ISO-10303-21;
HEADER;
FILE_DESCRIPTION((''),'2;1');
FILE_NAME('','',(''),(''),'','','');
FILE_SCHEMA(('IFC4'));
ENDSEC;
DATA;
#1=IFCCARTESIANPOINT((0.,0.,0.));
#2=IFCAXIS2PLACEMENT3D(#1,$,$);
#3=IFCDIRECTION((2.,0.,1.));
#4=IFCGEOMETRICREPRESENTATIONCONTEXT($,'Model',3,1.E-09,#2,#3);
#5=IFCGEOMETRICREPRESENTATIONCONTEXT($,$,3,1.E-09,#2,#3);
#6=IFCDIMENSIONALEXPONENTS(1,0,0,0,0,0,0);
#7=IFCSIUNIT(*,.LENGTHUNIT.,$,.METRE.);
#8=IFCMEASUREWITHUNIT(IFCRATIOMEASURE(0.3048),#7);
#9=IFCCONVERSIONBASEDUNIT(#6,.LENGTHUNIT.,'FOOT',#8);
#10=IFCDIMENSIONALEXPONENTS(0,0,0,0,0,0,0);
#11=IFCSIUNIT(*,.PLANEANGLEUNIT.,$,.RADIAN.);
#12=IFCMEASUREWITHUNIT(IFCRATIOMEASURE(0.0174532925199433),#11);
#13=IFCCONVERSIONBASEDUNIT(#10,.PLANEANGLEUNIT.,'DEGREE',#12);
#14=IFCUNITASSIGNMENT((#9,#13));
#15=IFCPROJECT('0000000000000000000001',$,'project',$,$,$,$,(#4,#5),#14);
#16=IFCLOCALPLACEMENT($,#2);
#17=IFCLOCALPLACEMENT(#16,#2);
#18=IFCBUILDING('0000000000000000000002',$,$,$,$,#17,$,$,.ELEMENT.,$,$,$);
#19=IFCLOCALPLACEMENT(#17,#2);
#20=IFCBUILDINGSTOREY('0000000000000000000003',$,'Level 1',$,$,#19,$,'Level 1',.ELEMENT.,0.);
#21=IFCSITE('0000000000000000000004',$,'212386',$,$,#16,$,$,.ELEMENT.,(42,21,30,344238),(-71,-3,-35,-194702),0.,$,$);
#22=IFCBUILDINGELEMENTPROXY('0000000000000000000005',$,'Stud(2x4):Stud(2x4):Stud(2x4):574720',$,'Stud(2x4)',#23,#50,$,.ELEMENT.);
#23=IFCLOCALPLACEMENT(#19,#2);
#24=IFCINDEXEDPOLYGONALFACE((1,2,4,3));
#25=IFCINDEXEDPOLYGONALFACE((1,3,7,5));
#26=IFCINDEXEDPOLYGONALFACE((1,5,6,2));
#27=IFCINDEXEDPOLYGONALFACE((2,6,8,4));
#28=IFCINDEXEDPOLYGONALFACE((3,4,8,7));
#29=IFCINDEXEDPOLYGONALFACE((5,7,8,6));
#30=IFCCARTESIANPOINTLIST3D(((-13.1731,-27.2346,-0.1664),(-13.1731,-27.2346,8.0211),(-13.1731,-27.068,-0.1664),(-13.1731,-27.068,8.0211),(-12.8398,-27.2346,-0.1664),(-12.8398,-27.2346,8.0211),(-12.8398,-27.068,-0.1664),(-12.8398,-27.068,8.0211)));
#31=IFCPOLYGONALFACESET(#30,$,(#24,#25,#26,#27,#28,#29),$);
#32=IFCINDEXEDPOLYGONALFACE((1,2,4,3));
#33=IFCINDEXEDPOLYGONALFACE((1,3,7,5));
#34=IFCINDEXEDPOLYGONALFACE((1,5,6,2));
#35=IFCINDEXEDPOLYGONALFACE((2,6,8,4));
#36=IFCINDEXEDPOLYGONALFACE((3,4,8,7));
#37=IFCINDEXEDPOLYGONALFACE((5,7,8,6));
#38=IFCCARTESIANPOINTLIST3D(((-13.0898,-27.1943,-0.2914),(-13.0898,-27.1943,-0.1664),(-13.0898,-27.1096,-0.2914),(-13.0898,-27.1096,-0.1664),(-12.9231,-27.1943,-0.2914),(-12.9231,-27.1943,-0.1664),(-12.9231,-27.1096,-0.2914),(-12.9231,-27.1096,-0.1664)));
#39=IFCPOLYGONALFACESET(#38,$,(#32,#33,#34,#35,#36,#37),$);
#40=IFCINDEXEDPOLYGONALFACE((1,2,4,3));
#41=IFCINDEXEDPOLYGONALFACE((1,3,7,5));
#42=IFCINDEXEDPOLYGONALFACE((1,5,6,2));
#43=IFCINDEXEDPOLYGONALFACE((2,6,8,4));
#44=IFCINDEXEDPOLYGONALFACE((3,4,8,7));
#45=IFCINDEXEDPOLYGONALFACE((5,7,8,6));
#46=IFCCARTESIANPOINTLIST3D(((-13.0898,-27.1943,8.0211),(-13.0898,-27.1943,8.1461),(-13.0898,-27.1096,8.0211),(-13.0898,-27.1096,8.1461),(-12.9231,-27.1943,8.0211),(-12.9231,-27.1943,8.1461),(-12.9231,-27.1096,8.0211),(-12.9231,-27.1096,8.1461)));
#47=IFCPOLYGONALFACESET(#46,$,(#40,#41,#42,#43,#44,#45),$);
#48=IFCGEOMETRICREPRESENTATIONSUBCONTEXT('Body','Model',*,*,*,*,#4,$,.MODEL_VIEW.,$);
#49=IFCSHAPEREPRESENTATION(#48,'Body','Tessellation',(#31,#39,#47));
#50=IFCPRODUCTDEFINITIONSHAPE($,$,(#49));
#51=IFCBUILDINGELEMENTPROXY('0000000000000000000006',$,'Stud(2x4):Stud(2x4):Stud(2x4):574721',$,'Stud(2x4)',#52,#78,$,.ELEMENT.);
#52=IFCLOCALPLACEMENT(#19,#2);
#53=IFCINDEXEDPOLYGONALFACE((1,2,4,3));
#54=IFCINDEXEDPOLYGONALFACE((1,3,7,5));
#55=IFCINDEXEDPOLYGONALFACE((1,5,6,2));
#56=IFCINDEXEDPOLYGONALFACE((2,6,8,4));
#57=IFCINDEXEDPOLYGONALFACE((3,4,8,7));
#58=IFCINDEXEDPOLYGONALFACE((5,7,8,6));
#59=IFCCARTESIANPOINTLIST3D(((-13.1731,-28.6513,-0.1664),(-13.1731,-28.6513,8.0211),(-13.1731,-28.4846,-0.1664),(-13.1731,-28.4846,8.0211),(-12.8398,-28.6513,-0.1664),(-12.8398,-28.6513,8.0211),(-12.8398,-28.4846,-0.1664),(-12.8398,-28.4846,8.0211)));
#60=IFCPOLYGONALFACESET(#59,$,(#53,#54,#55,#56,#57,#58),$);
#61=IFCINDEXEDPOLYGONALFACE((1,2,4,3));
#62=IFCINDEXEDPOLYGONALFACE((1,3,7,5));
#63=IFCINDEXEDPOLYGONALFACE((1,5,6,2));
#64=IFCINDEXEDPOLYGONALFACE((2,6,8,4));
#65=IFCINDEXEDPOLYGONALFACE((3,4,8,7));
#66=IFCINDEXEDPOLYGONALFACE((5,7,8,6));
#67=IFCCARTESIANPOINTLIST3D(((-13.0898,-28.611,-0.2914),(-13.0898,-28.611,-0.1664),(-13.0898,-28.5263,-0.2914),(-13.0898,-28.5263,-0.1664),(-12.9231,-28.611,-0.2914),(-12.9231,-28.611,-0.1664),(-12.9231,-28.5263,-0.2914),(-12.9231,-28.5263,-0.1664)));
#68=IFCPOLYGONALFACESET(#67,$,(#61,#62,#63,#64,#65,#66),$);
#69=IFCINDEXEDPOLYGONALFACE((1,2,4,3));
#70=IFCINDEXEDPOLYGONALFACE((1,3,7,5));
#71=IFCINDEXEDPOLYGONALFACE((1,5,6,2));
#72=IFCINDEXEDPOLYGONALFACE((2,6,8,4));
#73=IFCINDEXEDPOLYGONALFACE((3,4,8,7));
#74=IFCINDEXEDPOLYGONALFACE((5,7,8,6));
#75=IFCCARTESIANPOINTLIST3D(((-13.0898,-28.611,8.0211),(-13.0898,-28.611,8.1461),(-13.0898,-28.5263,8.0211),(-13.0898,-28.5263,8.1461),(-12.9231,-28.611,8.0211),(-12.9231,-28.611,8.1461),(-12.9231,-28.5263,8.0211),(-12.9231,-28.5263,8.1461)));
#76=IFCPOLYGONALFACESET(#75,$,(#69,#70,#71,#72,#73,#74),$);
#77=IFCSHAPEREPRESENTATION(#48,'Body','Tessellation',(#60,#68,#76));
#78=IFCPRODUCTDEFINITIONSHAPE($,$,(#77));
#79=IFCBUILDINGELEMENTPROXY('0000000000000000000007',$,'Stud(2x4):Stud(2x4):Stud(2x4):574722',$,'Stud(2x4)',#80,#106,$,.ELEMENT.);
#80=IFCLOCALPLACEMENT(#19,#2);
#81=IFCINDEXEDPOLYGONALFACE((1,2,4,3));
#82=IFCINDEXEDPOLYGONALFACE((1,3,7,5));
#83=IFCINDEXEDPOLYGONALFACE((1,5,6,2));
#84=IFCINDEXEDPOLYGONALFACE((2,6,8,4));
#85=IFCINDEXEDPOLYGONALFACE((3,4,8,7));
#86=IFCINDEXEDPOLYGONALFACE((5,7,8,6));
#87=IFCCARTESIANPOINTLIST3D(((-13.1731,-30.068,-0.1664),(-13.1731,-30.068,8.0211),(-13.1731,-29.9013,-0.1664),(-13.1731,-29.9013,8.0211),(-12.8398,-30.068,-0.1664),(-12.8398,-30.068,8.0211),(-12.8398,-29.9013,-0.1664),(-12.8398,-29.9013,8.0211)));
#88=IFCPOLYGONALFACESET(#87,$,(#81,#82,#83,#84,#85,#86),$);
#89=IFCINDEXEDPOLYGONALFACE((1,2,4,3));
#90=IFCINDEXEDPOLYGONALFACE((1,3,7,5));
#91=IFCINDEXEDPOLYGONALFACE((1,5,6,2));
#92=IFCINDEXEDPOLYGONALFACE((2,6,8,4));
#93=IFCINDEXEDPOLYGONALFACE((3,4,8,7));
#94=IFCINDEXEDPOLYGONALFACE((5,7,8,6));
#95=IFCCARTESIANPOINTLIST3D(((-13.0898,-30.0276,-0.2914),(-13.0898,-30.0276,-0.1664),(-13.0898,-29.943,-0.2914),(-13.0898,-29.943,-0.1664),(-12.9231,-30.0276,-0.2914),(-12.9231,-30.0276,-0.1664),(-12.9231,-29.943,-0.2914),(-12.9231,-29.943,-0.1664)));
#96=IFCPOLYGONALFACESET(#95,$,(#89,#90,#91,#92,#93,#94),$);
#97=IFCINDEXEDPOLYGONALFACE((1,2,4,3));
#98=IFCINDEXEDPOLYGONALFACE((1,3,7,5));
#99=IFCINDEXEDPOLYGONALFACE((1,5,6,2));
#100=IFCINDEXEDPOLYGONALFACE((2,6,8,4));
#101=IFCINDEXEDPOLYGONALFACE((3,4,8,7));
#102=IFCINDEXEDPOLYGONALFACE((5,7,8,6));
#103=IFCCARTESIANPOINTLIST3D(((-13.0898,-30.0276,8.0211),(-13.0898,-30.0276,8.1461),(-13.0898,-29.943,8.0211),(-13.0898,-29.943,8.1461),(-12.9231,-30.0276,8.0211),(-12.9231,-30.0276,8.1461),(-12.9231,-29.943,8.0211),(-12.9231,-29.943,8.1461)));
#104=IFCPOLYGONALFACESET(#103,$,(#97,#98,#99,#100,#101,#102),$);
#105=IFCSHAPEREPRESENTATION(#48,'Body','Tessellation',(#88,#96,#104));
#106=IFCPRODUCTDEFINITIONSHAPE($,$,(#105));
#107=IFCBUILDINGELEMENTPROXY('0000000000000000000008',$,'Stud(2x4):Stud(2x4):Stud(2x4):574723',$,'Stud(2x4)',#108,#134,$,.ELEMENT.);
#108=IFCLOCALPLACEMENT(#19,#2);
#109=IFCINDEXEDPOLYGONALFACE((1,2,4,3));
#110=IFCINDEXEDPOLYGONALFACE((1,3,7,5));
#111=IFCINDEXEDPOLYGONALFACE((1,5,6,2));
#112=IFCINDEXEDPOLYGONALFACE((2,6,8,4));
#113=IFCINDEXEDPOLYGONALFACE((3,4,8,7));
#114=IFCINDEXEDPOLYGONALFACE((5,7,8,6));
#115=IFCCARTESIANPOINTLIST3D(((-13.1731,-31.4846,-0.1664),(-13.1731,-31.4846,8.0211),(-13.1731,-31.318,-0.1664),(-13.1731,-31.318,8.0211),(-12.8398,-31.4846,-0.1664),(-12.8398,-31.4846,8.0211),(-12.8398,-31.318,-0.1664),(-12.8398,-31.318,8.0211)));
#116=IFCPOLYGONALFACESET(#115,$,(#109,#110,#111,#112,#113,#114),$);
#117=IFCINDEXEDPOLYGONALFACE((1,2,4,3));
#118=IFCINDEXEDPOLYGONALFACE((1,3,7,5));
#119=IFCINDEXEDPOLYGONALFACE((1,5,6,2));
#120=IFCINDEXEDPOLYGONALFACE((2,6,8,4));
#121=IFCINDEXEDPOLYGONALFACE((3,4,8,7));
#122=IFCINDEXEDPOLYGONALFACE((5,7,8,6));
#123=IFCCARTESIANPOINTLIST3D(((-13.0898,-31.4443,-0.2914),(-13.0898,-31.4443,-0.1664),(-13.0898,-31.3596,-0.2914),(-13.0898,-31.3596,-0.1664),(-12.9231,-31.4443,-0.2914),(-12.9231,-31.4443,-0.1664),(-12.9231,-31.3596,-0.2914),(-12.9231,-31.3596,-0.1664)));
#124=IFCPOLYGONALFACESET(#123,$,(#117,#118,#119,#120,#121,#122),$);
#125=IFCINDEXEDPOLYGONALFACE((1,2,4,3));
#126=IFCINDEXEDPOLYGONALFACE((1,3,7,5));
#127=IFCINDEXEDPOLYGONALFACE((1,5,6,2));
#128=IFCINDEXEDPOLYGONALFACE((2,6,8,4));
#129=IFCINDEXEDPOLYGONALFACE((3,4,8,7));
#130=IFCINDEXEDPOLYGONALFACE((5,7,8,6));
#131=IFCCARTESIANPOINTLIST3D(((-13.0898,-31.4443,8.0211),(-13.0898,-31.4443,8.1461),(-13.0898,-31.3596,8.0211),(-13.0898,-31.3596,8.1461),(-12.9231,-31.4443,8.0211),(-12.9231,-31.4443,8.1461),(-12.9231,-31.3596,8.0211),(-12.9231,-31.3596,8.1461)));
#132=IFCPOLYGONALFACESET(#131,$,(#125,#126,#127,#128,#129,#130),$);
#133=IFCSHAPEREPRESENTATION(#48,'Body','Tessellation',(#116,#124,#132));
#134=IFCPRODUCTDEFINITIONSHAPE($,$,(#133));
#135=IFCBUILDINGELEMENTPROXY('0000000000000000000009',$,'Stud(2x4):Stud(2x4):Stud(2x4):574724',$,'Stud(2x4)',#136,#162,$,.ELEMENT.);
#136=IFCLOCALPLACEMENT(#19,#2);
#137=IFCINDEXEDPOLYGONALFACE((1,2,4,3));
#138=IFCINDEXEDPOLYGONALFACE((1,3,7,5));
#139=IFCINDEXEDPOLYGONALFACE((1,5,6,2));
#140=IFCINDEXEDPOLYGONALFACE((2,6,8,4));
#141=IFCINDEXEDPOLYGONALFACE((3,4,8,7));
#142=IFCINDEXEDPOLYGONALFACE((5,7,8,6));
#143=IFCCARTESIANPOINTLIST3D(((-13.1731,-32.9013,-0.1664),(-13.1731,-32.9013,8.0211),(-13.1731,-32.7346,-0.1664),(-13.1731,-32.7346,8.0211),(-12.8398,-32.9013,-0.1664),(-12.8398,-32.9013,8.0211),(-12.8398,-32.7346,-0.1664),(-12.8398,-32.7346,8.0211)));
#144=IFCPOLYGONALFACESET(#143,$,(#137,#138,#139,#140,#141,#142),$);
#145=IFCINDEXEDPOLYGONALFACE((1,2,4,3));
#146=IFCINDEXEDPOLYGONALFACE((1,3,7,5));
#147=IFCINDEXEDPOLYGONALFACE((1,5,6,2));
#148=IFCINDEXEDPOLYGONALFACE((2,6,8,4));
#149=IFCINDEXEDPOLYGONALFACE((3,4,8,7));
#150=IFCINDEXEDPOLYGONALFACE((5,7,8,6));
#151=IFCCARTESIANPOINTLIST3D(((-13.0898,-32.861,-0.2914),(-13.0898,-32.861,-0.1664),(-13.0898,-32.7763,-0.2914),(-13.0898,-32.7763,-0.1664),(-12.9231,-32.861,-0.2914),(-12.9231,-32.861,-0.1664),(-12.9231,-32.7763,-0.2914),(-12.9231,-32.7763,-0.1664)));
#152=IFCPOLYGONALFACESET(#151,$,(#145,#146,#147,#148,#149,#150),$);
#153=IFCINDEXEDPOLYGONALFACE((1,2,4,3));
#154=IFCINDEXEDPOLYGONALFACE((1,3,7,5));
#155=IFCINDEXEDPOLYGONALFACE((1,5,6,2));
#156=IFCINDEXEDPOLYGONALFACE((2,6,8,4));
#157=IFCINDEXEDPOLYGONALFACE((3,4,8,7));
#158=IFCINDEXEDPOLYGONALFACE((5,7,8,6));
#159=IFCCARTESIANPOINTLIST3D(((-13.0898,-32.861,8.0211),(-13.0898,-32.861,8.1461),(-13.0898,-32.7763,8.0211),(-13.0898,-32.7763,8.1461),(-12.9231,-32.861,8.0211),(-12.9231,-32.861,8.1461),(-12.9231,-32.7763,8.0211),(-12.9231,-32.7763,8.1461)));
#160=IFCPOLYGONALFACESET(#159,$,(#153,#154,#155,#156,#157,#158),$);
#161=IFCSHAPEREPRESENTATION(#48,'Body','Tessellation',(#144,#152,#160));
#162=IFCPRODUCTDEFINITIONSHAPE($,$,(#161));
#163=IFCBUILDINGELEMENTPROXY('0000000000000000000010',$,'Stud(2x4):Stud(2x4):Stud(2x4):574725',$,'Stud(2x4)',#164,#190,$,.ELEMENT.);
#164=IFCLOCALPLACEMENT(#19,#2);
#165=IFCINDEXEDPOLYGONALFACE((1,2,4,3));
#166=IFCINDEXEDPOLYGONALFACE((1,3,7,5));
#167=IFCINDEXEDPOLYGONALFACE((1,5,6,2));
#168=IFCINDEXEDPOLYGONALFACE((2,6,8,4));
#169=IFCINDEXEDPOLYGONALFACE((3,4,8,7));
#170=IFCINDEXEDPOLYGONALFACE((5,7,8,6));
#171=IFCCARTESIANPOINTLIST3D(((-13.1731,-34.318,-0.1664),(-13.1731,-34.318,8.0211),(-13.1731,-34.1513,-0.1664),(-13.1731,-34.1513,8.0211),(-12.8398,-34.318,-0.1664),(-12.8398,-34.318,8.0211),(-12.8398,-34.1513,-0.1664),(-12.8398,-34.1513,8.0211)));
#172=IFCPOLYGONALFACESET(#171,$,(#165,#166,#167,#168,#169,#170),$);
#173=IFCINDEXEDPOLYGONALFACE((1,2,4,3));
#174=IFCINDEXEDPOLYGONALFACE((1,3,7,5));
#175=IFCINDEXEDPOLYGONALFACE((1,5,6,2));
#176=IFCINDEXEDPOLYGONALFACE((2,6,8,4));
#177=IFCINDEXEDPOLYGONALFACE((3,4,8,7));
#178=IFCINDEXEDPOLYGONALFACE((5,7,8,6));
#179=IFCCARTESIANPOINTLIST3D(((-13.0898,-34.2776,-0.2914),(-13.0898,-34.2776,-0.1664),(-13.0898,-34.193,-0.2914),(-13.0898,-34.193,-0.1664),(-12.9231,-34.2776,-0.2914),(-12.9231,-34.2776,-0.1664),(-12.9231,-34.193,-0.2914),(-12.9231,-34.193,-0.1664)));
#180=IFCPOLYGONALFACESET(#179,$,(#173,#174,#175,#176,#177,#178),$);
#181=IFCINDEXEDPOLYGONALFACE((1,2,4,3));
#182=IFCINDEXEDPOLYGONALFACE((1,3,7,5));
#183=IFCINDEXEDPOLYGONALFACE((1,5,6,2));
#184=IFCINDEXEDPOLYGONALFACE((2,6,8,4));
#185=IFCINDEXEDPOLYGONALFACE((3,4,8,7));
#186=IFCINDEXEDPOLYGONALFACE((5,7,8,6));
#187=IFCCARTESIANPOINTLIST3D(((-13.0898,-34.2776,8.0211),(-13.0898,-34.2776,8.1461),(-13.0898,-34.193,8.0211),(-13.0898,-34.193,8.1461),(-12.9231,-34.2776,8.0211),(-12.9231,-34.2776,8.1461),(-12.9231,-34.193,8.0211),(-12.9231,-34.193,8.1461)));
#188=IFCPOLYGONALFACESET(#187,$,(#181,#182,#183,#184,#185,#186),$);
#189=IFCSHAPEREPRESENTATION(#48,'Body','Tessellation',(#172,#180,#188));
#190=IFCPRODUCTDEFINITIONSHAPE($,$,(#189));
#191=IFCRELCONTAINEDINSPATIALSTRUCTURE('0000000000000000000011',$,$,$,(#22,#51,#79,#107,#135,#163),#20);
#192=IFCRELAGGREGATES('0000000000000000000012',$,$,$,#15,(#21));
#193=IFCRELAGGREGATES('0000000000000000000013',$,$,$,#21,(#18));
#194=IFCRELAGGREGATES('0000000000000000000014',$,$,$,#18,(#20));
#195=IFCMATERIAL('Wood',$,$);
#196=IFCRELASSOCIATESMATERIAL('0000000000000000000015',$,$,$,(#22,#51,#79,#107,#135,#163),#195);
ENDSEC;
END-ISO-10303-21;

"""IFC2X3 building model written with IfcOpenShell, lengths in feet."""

from ifc_helpers import new_model, entity, si_unit, converted_unit, direction, frame, frame_2d, origin, place, context, subcontext, project, spatial, rectangle, extrude, source, transform, mapped, material, element, save


model = new_model("IFC2X3")

# Units and contexts
model_context = context("Model", 3, precision=1e-09, world=origin(), true_north=direction((2.0, 0.0, 1.0)))
context_of_model = context(None, 3, precision=1e-09, world=origin(), true_north=direction((2.0, 0.0, 1.0)))
body_context = subcontext(model_context, "Body", "Model", "MODEL_VIEW")
ifc_project = project(units=[converted_unit("LENGTHUNIT", "FOOT", entity("IfcRatioMeasure", 0.3048), si_unit("LENGTHUNIT", "METRE"), dimensions=[1, 0, 0, 0, 0, 0, 0]), converted_unit("PLANEANGLEUNIT", "DEGREE", entity("IfcRatioMeasure", 0.0174532925199433), si_unit("PLANEANGLEUNIT", "RADIAN"), dimensions=[0, 0, 0, 0, 0, 0, 0])], contexts=[model_context, context_of_model])

# Site, building, storey
site_placement = place(None, origin())
site = spatial("IfcSite", under=ifc_project, at=site_placement, Name="212386", CompositionType="ELEMENT", RefLatitude=(42, 21, 30, 344238), RefLongitude=(-71, -3, -35, -194702), RefElevation=0.0)
building_placement = place(site_placement, origin())
building = spatial("IfcBuilding", under=site, at=building_placement, CompositionType="ELEMENT")
storey_placement = place(building_placement, origin())
storey = spatial("IfcBuildingStorey", under=building, at=storey_placement, Name="Level 1", LongName="Level 1", CompositionType="ELEMENT", Elevation=0.0)

# Building element proxies
ifc_material = material(Name="Wood")
shared_shape_1 = source(origin(), body_context, "Body", "SweptSolid", [
    extrude(rectangle(XDim=0.3333, YDim=0.1667, at=frame_2d((0.0, 0.0), x_axis=(1.0, 0.0))), frame((-13.0064, -27.1513, -0.1664), z_axis=(0.0, 0.0, 1.0), x_axis=(-1.0, 0.0, 0.0)), (0.0, 0.0, 1.0), 8.1875),
    extrude(rectangle(XDim=0.1667, YDim=0.0847, at=frame_2d((0.0, 0.0), x_axis=(1.0, 0.0))), frame((-13.0064, -27.152, -0.2914), z_axis=(0.0, 0.0, 1.0), x_axis=(-1.0, 0.0, 0.0)), (0.0, 0.0, 1.0), 0.125),
    extrude(rectangle(XDim=0.0847, YDim=0.1667, at=frame_2d((0.0, 0.0), x_axis=(1.0, 0.0))), frame((-13.0064, -27.152, 8.0211), z_axis=(0.0, 0.0, 1.0), x_axis=(0.0, -1.0, 0.0)), (0.0, 0.0, 1.0), 0.125),
])
proxy_1_placement = place(storey_placement, origin())
element("IfcBuildingElementProxy", 1, at=proxy_1_placement, inside=storey, material=ifc_material, Name="Stud(2x4):Stud(2x4):Stud(2x4):574720", ObjectType="Stud(2x4)", CompositionType="ELEMENT", context=body_context, shape_type="MappedRepresentation", body=[
    mapped(shared_shape_1, transform((0.0, 0.0, 0.0), scale=1.0)),
])
shared_shape_2 = source(origin(), body_context, "Body", "SweptSolid", [
    extrude(rectangle(XDim=0.3333, YDim=0.1667, at=frame_2d((0.0, 0.0), x_axis=(1.0, 0.0))), frame((-13.0064, -28.568, -0.1664), z_axis=(0.0, 0.0, 1.0), x_axis=(-1.0, 0.0, 0.0)), (0.0, 0.0, 1.0), 8.1875),
    extrude(rectangle(XDim=0.1667, YDim=0.0847, at=frame_2d((0.0, 0.0), x_axis=(1.0, 0.0))), frame((-13.0064, -28.5686, -0.2914), z_axis=(0.0, 0.0, 1.0), x_axis=(-1.0, 0.0, 0.0)), (0.0, 0.0, 1.0), 0.125),
    extrude(rectangle(XDim=0.0847, YDim=0.1667, at=frame_2d((0.0, 0.0), x_axis=(1.0, 0.0))), frame((-13.0064, -28.5686, 8.0211), z_axis=(0.0, 0.0, 1.0), x_axis=(0.0, -1.0, 0.0)), (0.0, 0.0, 1.0), 0.125),
])
proxy_2_placement = place(storey_placement, origin())
element("IfcBuildingElementProxy", 2, at=proxy_2_placement, inside=storey, material=ifc_material, Name="Stud(2x4):Stud(2x4):Stud(2x4):574721", ObjectType="Stud(2x4)", CompositionType="ELEMENT", context=body_context, shape_type="MappedRepresentation", body=[
    mapped(shared_shape_2, transform((0.0, 0.0, 0.0), scale=1.0)),
])
shared_shape_3 = source(origin(), body_context, "Body", "SweptSolid", [
    extrude(rectangle(XDim=0.3333, YDim=0.1667, at=frame_2d((0.0, 0.0), x_axis=(1.0, 0.0))), frame((-13.0064, -29.9846, -0.1664), z_axis=(0.0, 0.0, 1.0), x_axis=(-1.0, 0.0, 0.0)), (0.0, 0.0, 1.0), 8.1875),
    extrude(rectangle(XDim=0.1667, YDim=0.0847, at=frame_2d((0.0, 0.0), x_axis=(1.0, 0.0))), frame((-13.0064, -29.9853, -0.2914), z_axis=(0.0, 0.0, 1.0), x_axis=(-1.0, 0.0, 0.0)), (0.0, 0.0, 1.0), 0.125),
    extrude(rectangle(XDim=0.0847, YDim=0.1667, at=frame_2d((0.0, 0.0), x_axis=(1.0, 0.0))), frame((-13.0064, -29.9853, 8.0211), z_axis=(0.0, 0.0, 1.0), x_axis=(0.0, -1.0, 0.0)), (0.0, 0.0, 1.0), 0.125),
])
proxy_3_placement = place(storey_placement, origin())
element("IfcBuildingElementProxy", 3, at=proxy_3_placement, inside=storey, material=ifc_material, Name="Stud(2x4):Stud(2x4):Stud(2x4):574722", ObjectType="Stud(2x4)", CompositionType="ELEMENT", context=body_context, shape_type="MappedRepresentation", body=[
    mapped(shared_shape_3, transform((0.0, 0.0, 0.0), scale=1.0)),
])
shared_shape_4 = source(origin(), body_context, "Body", "SweptSolid", [
    extrude(rectangle(XDim=0.3333, YDim=0.1667, at=frame_2d((0.0, 0.0), x_axis=(1.0, 0.0))), frame((-13.0064, -31.4013, -0.1664), z_axis=(0.0, 0.0, 1.0), x_axis=(-1.0, 0.0, 0.0)), (0.0, 0.0, 1.0), 8.1875),
    extrude(rectangle(XDim=0.1667, YDim=0.0847, at=frame_2d((0.0, 0.0), x_axis=(1.0, 0.0))), frame((-13.0064, -31.402, -0.2914), z_axis=(0.0, 0.0, 1.0), x_axis=(-1.0, 0.0, 0.0)), (0.0, 0.0, 1.0), 0.125),
    extrude(rectangle(XDim=0.0847, YDim=0.1667, at=frame_2d((0.0, 0.0), x_axis=(1.0, 0.0))), frame((-13.0064, -31.402, 8.0211), z_axis=(0.0, 0.0, 1.0), x_axis=(0.0, -1.0, 0.0)), (0.0, 0.0, 1.0), 0.125),
])
proxy_4_placement = place(storey_placement, origin())
element("IfcBuildingElementProxy", 4, at=proxy_4_placement, inside=storey, material=ifc_material, Name="Stud(2x4):Stud(2x4):Stud(2x4):574723", ObjectType="Stud(2x4)", CompositionType="ELEMENT", context=body_context, shape_type="MappedRepresentation", body=[
    mapped(shared_shape_4, transform((0.0, 0.0, 0.0), scale=1.0)),
])
shared_shape_5 = source(origin(), body_context, "Body", "SweptSolid", [
    extrude(rectangle(XDim=0.3333, YDim=0.1667, at=frame_2d((0.0, 0.0), x_axis=(1.0, 0.0))), frame((-13.0064, -32.818, -0.1664), z_axis=(0.0, 0.0, 1.0), x_axis=(-1.0, 0.0, 0.0)), (0.0, 0.0, 1.0), 8.1875),
    extrude(rectangle(XDim=0.1667, YDim=0.0847, at=frame_2d((0.0, 0.0), x_axis=(1.0, 0.0))), frame((-13.0064, -32.8186, -0.2914), z_axis=(0.0, 0.0, 1.0), x_axis=(-1.0, 0.0, 0.0)), (0.0, 0.0, 1.0), 0.125),
    extrude(rectangle(XDim=0.0847, YDim=0.1667, at=frame_2d((0.0, 0.0), x_axis=(1.0, 0.0))), frame((-13.0064, -32.8186, 8.0211), z_axis=(0.0, 0.0, 1.0), x_axis=(0.0, -1.0, 0.0)), (0.0, 0.0, 1.0), 0.125),
])
proxy_5_placement = place(storey_placement, origin())
element("IfcBuildingElementProxy", 5, at=proxy_5_placement, inside=storey, material=ifc_material, Name="Stud(2x4):Stud(2x4):Stud(2x4):574724", ObjectType="Stud(2x4)", CompositionType="ELEMENT", context=body_context, shape_type="MappedRepresentation", body=[
    mapped(shared_shape_5, transform((0.0, 0.0, 0.0), scale=1.0)),
])
shared_shape_6 = source(origin(), body_context, "Body", "SweptSolid", [
    extrude(rectangle(XDim=0.3333, YDim=0.1667, at=frame_2d((0.0, 0.0), x_axis=(1.0, 0.0))), frame((-13.0064, -34.2346, -0.1664), z_axis=(0.0, 0.0, 1.0), x_axis=(-1.0, 0.0, 0.0)), (0.0, 0.0, 1.0), 8.1875),
    extrude(rectangle(XDim=0.1667, YDim=0.0847, at=frame_2d((0.0, 0.0), x_axis=(1.0, 0.0))), frame((-13.0064, -34.2353, -0.2914), z_axis=(0.0, 0.0, 1.0), x_axis=(-1.0, 0.0, 0.0)), (0.0, 0.0, 1.0), 0.125),
    extrude(rectangle(XDim=0.0847, YDim=0.1667, at=frame_2d((0.0, 0.0), x_axis=(1.0, 0.0))), frame((-13.0064, -34.2353, 8.0211), z_axis=(0.0, 0.0, 1.0), x_axis=(0.0, -1.0, 0.0)), (0.0, 0.0, 1.0), 0.125),
])
proxy_6_placement = place(storey_placement, origin())
element("IfcBuildingElementProxy", 6, at=proxy_6_placement, inside=storey, material=ifc_material, Name="Stud(2x4):Stud(2x4):Stud(2x4):574725", ObjectType="Stud(2x4)", CompositionType="ELEMENT", context=body_context, shape_type="MappedRepresentation", body=[
    mapped(shared_shape_6, transform((0.0, 0.0, 0.0), scale=1.0)),
])

save(model, "model.ifc")
